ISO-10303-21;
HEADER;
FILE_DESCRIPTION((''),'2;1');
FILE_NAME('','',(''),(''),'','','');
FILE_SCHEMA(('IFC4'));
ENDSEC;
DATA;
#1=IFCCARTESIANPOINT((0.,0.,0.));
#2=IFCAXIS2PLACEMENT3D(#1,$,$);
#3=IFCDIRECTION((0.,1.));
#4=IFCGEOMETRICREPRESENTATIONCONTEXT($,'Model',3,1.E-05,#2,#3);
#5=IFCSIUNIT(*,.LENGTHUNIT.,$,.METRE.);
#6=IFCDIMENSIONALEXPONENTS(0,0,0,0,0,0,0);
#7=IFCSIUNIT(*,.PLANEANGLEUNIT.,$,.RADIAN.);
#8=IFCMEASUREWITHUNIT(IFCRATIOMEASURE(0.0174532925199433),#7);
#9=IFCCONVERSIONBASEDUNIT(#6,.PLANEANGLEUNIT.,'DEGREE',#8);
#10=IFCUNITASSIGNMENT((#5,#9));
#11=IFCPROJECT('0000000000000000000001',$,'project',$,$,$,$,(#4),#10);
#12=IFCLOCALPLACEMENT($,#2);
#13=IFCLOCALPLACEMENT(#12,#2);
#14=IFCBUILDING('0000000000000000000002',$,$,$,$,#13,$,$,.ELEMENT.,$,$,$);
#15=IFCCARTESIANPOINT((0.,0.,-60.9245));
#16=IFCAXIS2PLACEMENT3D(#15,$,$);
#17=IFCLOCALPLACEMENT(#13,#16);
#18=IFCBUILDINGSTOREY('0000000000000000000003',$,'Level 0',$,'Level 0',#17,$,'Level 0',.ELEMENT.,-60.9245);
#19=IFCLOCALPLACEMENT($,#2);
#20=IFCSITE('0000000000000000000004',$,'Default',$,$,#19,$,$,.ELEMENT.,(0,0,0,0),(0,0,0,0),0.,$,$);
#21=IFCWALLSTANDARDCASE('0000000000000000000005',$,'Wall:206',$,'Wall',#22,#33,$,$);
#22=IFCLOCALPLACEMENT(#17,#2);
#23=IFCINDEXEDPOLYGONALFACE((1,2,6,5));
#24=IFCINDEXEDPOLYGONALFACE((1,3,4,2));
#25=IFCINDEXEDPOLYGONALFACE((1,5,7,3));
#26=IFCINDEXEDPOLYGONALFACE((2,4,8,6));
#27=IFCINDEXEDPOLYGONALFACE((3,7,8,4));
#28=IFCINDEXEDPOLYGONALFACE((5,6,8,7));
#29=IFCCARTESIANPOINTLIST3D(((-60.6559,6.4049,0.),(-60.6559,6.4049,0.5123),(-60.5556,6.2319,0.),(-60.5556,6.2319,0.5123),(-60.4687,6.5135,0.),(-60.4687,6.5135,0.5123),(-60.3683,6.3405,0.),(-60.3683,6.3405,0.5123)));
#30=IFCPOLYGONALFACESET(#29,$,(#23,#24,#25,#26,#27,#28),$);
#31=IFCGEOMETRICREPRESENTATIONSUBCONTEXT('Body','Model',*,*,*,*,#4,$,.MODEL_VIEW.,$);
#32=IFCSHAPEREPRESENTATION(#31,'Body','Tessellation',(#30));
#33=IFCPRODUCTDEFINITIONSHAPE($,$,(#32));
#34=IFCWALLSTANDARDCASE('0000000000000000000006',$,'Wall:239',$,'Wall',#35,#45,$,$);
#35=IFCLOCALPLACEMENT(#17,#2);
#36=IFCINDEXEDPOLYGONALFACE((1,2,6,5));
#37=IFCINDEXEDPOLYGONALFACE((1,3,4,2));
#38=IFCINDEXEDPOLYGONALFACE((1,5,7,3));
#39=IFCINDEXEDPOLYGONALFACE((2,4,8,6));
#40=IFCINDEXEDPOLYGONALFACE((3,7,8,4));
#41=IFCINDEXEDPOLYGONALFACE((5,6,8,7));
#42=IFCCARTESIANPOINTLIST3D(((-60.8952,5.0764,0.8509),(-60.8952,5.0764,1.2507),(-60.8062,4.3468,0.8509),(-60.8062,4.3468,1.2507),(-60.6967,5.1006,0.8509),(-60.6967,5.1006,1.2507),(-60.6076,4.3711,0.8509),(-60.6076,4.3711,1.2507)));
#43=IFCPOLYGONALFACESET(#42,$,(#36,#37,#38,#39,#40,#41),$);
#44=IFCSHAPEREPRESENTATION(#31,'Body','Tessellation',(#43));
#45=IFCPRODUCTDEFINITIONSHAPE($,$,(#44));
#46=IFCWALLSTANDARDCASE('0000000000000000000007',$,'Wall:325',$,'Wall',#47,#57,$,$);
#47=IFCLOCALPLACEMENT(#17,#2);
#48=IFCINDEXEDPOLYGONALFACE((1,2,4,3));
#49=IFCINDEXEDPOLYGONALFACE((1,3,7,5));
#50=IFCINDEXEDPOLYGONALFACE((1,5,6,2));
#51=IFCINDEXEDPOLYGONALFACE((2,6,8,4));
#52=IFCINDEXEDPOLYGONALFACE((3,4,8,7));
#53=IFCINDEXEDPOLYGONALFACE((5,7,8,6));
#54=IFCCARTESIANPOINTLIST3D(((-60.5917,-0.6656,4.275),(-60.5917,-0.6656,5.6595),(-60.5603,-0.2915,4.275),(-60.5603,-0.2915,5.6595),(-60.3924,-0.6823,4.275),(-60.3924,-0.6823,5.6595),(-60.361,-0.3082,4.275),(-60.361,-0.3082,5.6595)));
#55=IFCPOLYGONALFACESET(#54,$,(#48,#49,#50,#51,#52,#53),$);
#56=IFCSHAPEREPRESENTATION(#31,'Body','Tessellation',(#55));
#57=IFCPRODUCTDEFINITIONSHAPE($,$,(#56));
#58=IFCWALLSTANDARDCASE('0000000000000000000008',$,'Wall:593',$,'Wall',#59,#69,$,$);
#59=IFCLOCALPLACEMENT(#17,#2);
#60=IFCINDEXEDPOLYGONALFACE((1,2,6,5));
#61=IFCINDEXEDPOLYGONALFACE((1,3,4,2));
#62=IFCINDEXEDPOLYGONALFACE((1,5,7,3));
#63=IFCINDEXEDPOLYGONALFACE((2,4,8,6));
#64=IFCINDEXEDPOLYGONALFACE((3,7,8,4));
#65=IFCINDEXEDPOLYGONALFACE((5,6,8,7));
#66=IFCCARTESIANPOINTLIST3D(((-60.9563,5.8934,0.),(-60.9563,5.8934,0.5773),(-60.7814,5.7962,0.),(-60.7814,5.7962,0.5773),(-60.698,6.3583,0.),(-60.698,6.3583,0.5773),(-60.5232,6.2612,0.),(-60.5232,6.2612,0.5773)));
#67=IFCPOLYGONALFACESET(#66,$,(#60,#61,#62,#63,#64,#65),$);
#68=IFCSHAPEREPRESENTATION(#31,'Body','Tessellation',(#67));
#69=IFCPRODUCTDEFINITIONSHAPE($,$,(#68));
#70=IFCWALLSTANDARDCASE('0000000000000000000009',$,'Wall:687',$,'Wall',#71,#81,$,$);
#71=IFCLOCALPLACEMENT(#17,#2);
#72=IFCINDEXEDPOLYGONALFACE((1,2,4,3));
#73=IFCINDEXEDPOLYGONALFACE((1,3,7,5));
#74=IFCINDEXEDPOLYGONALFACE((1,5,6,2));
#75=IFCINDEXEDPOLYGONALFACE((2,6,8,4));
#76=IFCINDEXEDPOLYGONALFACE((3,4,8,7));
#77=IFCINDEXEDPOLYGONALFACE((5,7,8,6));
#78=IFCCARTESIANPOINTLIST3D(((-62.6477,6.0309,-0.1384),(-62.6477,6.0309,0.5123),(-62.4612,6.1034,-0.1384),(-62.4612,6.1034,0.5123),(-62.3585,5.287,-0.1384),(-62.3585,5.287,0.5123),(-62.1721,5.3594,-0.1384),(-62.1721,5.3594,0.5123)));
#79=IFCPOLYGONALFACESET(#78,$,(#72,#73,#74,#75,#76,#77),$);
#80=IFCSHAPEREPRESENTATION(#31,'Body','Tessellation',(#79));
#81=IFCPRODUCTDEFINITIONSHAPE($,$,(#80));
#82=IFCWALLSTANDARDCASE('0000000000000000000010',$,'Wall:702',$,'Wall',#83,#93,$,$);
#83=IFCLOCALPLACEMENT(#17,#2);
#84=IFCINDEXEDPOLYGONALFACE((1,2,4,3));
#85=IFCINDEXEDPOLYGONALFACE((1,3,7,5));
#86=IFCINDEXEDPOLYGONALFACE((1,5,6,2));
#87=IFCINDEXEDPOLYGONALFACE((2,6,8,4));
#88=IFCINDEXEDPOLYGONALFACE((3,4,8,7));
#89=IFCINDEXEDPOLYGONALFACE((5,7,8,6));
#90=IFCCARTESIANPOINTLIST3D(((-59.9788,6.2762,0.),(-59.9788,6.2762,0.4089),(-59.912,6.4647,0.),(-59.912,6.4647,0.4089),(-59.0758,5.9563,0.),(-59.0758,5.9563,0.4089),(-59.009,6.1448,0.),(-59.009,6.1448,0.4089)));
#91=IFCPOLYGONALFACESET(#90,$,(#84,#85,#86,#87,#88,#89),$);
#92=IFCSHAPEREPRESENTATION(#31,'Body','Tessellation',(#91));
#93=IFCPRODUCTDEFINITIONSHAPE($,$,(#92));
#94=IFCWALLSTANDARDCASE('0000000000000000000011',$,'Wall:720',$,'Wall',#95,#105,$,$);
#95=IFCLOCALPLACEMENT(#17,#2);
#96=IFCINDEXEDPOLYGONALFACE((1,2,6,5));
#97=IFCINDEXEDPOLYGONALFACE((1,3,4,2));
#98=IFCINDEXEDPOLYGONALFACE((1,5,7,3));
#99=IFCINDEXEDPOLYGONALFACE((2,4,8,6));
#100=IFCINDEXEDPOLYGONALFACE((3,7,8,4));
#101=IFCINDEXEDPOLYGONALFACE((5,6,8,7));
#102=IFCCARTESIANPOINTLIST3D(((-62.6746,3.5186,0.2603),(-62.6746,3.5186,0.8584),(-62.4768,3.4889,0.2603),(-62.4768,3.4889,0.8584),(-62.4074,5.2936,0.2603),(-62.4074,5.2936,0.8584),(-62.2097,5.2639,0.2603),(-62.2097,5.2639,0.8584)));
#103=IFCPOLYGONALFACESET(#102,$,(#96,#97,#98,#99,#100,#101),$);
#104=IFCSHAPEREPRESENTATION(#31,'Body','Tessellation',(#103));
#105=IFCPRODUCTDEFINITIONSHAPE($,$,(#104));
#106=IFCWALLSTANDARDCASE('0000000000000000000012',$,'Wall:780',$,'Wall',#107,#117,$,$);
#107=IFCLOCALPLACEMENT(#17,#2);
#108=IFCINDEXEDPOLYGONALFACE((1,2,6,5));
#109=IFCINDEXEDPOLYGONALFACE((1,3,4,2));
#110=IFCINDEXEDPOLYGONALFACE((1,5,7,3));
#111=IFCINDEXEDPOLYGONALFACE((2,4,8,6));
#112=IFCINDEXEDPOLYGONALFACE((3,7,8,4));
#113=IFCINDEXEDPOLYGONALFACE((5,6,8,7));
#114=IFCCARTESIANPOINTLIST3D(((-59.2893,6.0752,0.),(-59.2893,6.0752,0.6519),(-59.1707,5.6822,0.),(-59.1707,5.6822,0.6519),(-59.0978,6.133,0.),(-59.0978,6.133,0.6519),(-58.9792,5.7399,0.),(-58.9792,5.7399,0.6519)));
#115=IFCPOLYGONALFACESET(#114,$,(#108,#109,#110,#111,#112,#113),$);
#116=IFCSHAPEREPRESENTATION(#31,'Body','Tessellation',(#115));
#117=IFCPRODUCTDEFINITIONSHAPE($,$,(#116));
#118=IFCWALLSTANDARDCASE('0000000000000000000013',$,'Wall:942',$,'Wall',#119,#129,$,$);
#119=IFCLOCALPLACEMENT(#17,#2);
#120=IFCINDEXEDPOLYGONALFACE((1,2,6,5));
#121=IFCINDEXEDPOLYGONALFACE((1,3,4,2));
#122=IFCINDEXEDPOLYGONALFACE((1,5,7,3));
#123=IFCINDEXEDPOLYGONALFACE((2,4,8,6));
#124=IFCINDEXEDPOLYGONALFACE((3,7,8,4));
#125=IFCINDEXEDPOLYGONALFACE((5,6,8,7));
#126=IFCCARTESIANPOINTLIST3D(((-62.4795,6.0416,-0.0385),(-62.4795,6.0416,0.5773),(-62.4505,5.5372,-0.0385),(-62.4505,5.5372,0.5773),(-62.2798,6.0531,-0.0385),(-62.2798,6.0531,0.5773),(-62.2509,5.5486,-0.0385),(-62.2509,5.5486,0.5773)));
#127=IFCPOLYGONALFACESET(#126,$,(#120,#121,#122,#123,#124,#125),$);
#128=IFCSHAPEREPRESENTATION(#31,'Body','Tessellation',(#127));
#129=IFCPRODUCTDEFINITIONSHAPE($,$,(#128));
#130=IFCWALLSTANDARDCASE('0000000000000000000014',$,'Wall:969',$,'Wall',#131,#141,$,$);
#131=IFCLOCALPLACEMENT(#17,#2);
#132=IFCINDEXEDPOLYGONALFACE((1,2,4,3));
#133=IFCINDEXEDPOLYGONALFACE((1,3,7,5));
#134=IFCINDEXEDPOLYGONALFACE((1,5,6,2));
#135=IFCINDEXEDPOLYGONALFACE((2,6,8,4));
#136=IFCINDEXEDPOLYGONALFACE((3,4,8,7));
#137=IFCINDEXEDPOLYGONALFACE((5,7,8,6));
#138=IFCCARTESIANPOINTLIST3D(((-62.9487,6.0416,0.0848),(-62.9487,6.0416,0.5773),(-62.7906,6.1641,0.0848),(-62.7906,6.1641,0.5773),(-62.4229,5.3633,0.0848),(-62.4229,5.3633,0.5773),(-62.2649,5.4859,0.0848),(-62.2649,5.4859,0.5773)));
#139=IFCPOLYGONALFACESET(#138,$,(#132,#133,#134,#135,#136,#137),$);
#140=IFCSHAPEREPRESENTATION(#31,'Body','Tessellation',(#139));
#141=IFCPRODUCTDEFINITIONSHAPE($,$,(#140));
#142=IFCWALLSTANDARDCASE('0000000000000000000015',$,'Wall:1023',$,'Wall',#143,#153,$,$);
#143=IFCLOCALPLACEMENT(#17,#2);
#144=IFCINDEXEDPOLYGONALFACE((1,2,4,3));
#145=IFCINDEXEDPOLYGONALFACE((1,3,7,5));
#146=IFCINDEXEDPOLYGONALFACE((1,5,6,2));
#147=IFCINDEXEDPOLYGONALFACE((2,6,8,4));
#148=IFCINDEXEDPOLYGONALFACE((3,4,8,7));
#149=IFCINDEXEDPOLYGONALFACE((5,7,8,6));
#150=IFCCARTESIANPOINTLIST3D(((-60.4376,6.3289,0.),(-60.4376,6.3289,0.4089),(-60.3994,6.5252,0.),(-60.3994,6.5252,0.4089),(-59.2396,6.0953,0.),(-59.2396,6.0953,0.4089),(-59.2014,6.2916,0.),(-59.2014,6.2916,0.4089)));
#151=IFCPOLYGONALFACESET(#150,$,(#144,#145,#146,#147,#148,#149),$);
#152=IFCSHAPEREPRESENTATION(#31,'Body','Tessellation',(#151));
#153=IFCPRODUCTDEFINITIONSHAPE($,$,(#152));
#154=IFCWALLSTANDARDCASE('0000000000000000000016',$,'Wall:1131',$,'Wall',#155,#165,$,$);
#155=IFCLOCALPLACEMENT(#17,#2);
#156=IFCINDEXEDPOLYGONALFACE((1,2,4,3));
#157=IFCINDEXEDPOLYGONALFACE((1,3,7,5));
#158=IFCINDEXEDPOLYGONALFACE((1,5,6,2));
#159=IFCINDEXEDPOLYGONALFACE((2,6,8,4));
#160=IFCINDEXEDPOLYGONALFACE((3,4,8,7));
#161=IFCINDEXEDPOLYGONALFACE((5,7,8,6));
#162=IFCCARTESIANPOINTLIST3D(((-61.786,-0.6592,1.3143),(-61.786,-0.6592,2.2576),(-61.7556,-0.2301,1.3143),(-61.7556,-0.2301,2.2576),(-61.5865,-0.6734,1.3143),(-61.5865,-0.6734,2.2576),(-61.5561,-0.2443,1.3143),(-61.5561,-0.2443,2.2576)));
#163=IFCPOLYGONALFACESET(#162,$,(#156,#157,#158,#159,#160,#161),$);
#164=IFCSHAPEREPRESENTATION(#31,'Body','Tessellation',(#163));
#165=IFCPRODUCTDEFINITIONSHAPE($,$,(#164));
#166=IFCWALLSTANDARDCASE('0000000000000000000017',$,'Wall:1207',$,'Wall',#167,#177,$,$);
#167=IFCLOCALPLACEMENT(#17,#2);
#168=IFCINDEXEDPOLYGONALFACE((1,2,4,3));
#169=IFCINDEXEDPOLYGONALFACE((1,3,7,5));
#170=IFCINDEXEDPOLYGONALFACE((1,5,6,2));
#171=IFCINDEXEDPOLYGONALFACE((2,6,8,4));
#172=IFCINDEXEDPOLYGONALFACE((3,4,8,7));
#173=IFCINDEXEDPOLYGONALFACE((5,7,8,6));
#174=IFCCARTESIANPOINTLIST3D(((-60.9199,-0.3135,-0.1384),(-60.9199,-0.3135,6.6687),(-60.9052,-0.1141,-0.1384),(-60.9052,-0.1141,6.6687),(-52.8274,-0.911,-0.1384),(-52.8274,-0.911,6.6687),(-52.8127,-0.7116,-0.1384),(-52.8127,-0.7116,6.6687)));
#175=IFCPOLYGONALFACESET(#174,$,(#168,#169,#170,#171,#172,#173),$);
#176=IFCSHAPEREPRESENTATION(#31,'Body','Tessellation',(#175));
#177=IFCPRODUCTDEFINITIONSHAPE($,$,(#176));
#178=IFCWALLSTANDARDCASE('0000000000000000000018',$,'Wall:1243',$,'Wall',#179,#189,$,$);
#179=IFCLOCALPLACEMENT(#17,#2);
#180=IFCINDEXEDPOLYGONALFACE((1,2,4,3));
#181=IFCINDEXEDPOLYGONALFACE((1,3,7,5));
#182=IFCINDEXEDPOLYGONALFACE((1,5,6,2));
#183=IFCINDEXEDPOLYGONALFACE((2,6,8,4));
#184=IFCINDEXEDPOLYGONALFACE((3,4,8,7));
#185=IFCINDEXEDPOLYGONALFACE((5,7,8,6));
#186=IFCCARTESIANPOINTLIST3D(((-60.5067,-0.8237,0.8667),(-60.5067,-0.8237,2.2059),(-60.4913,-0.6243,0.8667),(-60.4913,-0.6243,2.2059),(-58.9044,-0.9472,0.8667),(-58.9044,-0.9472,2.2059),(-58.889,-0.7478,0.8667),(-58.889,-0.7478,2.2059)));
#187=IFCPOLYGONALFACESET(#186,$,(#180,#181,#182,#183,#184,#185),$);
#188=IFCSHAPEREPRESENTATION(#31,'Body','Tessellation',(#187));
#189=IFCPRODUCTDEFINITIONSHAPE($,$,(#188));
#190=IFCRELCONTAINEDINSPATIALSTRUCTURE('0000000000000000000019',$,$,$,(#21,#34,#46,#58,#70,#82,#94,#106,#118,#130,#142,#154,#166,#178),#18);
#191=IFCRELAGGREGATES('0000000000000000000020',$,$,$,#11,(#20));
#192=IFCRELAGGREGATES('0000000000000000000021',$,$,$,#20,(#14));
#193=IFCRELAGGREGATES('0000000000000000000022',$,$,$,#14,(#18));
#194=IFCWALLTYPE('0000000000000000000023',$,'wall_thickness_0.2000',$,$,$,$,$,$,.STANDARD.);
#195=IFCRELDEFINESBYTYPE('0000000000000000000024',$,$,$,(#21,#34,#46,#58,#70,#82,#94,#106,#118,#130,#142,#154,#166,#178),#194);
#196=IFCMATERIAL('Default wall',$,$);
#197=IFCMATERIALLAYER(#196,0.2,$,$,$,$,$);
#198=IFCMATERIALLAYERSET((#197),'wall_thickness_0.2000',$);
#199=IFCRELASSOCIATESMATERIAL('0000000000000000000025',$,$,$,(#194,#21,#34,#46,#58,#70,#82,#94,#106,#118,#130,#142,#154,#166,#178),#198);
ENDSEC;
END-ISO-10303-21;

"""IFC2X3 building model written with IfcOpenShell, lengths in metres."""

from ifc_helpers import new_model, entity, si_unit, converted_unit, direction, frame, origin, place, context, subcontext, project, spatial, polyline, outline, extrude, material, layer, layer_set, layer_usage, type_object, element, save


model = new_model("IFC2X3")

# Units and contexts
model_context = context("Model", 3, precision=1e-05, world=origin(), true_north=direction((0.0, 1.0)))
body_context = subcontext(model_context, "Body", "Model", "MODEL_VIEW")
ifc_project = project(units=[si_unit("LENGTHUNIT", "METRE"), converted_unit("PLANEANGLEUNIT", "DEGREE", entity("IfcRatioMeasure", 0.0174532925199433), si_unit("PLANEANGLEUNIT", "RADIAN"), dimensions=[0, 0, 0, 0, 0, 0, 0])], contexts=[model_context])

# Site, building, storey
site_placement = place(None, origin())
site = spatial("IfcSite", under=ifc_project, at=site_placement, Name="Default", CompositionType="ELEMENT", RefLatitude=(0, 0, 0, 0), RefLongitude=(0, 0, 0, 0), RefElevation=0.0)
placement_1 = place(None, origin())
building_placement = place(placement_1, origin())
building = spatial("IfcBuilding", under=site, at=building_placement, CompositionType="ELEMENT")
storey_placement = place(building_placement, frame((0.0, 0.0, -60.9245)))
storey = spatial("IfcBuildingStorey", under=building, at=storey_placement, Name="Level 0", ObjectType="Level 0", LongName="Level 0", CompositionType="ELEMENT", Elevation=-60.9245)

# Walls
ifc_material = material(Name="Default wall")
ifc_layer = layer(ifc_material, 0.2)
ifc_layer_set = layer_set([ifc_layer], Name="wall_thickness_0.2000")
ifc_layer_usage = layer_usage(ifc_layer_set, "AXIS2", "POSITIVE", -0.1)
wall_type = type_object("IfcWallType", Name="wall_thickness_0.2000", PredefinedType="STANDARD", material=ifc_layer_set)
wall_1_placement = place(storey_placement, frame((-60.6058, 6.3184, 0.0), z_axis=(0.0, 0.0, 1.0), x_axis=(0.864993, 0.501783, 0.0)))
element("IfcWallStandardCase", 1, at=wall_1_placement, inside=storey, type_object=wall_type, material=ifc_layer_usage, Name="Wall:206", ObjectType="Wall", context=body_context, shape_type="SweptSolid", body=[
    extrude(outline(polyline([(0.2165, -0.1), (0.2165, 0.1), (0.0, 0.1), (0.0, -0.1), (0.2165, -0.1)])), origin(), (0.0, 0.0, 1.0), 0.5123),
])
placement_2 = place(building_placement, frame((0.0, 0.0, -60.0736)))
wall_2_placement = place(placement_2, frame((-60.796, 5.0885, 0.0), z_axis=(0.0, 0.0, 1.0), x_axis=(0.121209, -0.992627, 0.0)))
element("IfcWallStandardCase", 2, at=wall_2_placement, inside=storey, type_object=wall_type, material=ifc_layer_usage, Name="Wall:239", ObjectType="Wall", context=body_context, shape_type="SweptSolid", body=[
    extrude(outline(polyline([(0.735, -0.1), (0.735, 0.1), (0.0, 0.1), (0.0, -0.1), (0.735, -0.1)])), origin(), (0.0, 0.0, 1.0), 0.3998),
])
placement_3 = place(building_placement, frame((0.0, 0.0, -56.6495)))
wall_3_placement = place(placement_3, frame((-60.492, -0.6739, 0.0), z_axis=(0.0, 0.0, 1.0), x_axis=(0.08355, 0.996504, 0.0)))
element("IfcWallStandardCase", 3, at=wall_3_placement, inside=storey, type_object=wall_type, material=ifc_layer_usage, Name="Wall:325", ObjectType="Wall", context=body_context, shape_type="SweptSolid", body=[
    extrude(outline(polyline([(0.3754, -0.1), (0.3754, 0.1), (0.0, 0.1), (0.0, -0.1), (0.3754, -0.1)])), origin(), (0.0, 0.0, 1.0), 1.3845),
])
wall_4_placement = place(storey_placement, frame((-60.8689, 5.8448, 0.0), z_axis=(0.0, 0.0, 1.0), x_axis=(0.485631, 0.874164, 0.0)))
element("IfcWallStandardCase", 4, at=wall_4_placement, inside=storey, type_object=wall_type, material=ifc_layer_usage, Name="Wall:593", ObjectType="Wall", context=body_context, shape_type="SweptSolid", body=[
    extrude(outline(polyline([(0.5319, -0.1), (0.5319, 0.1), (0.0, 0.1), (0.0, -0.1), (0.5319, -0.1)])), origin(), (0.0, 0.0, 1.0), 0.5773),
])
placement_4 = place(building_placement, frame((0.0, 0.0, -61.0629)))
wall_5_placement = place(placement_4, frame((-62.2653, 5.3232, 0.0), z_axis=(0.0, 0.0, 1.0), x_axis=(-0.362264, 0.932076, 0.0)))
element("IfcWallStandardCase", 5, at=wall_5_placement, inside=storey, type_object=wall_type, material=ifc_layer_usage, Name="Wall:687", ObjectType="Wall", context=body_context, shape_type="SweptSolid", body=[
    extrude(outline(polyline([(0.7982, -0.1), (0.7982, 0.1), (0.0, 0.1), (0.0, -0.1), (0.7982, -0.1)])), origin(), (0.0, 0.0, 1.0), 0.6506),
])
wall_6_placement = place(storey_placement, frame((-59.0424, 6.0506, 0.0), z_axis=(0.0, 0.0, 1.0), x_axis=(-0.942624, 0.333856, 0.0)))
element("IfcWallStandardCase", 6, at=wall_6_placement, inside=storey, type_object=wall_type, material=ifc_layer_usage, Name="Wall:702", ObjectType="Wall", context=body_context, shape_type="SweptSolid", body=[
    extrude(outline(polyline([(0.958, -0.1), (0.958, 0.1), (0.0, 0.1), (0.0, -0.1), (0.958, -0.1)])), origin(), (0.0, 0.0, 1.0), 0.4089),
])
placement_5 = place(building_placement, frame((0.0, 0.0, -60.6642)))
wall_7_placement = place(placement_5, frame((-62.5757, 3.5038, 0.0), z_axis=(0.0, 0.0, 1.0), x_axis=(0.148826, 0.988863, 0.0)))
element("IfcWallStandardCase", 7, at=wall_7_placement, inside=storey, type_object=wall_type, material=ifc_layer_usage, Name="Wall:720", ObjectType="Wall", context=body_context, shape_type="SweptSolid", body=[
    extrude(outline(polyline([(1.795, -0.1), (1.795, 0.1), (0.0, 0.1), (0.0, -0.1), (1.795, -0.1)])), origin(), (0.0, 0.0, 1.0), 0.5981),
])
wall_8_placement = place(storey_placement, frame((-59.075, 5.7111, 0.0), z_axis=(0.0, 0.0, 1.0), x_axis=(-0.288823, 0.957383, 0.0)))
element("IfcWallStandardCase", 8, at=wall_8_placement, inside=storey, type_object=wall_type, material=ifc_layer_usage, Name="Wall:780", ObjectType="Wall", context=body_context, shape_type="SweptSolid", body=[
    extrude(outline(polyline([(0.4105, -0.1), (0.4105, 0.1), (0.0, 0.1), (0.0, -0.1), (0.4105, -0.1)])), origin(), (0.0, 0.0, 1.0), 0.6519),
])
placement_6 = place(building_placement, frame((0.0, 0.0, -60.963)))
wall_9_placement = place(placement_6, frame((-62.3507, 5.5429, 0.0), z_axis=(0.0, 0.0, 1.0), x_axis=(-0.057312, 0.998356, 0.0)))
element("IfcWallStandardCase", 9, at=wall_9_placement, inside=storey, type_object=wall_type, material=ifc_layer_usage, Name="Wall:942", ObjectType="Wall", context=body_context, shape_type="SweptSolid", body=[
    extrude(outline(polyline([(0.5053, -0.1), (0.5053, 0.1), (0.0, 0.1), (0.0, -0.1), (0.5053, -0.1)])), origin(), (0.0, 0.0, 1.0), 0.6158),
])
placement_7 = place(building_placement, frame((0.0, 0.0, -60.8397)))
wall_10_placement = place(placement_7, frame((-62.8696, 6.1029, 0.0), z_axis=(0.0, 0.0, 1.0), x_axis=(0.612608, -0.790387, 0.0)))
element("IfcWallStandardCase", 10, at=wall_10_placement, inside=storey, type_object=wall_type, material=ifc_layer_usage, Name="Wall:969", ObjectType="Wall", context=body_context, shape_type="SweptSolid", body=[
    extrude(outline(polyline([(0.8582, -0.1), (0.8582, 0.1), (0.0, 0.1), (0.0, -0.1), (0.8582, -0.1)])), origin(), (0.0, 0.0, 1.0), 0.4925),
])
wall_11_placement = place(storey_placement, frame((-60.4185, 6.427, 0.0), z_axis=(0.0, 0.0, 1.0), x_axis=(0.981525, -0.191334, 0.0)))
element("IfcWallStandardCase", 11, at=wall_11_placement, inside=storey, type_object=wall_type, material=ifc_layer_usage, Name="Wall:1023", ObjectType="Wall", context=body_context, shape_type="SweptSolid", body=[
    extrude(outline(polyline([(1.2205, -0.1), (1.2205, 0.1), (0.0, 0.1), (0.0, -0.1), (1.2205, -0.1)])), origin(), (0.0, 0.0, 1.0), 0.4089),
])
placement_8 = place(building_placement, frame((0.0, 0.0, -59.6102)))
wall_12_placement = place(placement_8, frame((-61.6558, -0.2372, 0.0), z_axis=(0.0, 0.0, 1.0), x_axis=(-0.070702, -0.997498, 0.0)))
element("IfcWallStandardCase", 12, at=wall_12_placement, inside=storey, type_object=wall_type, material=ifc_layer_usage, Name="Wall:1131", ObjectType="Wall", context=body_context, shape_type="SweptSolid", body=[
    extrude(outline(polyline([(0.4302, -0.1), (0.4302, 0.1), (0.0, 0.1), (0.0, -0.1), (0.4302, -0.1)])), origin(), (0.0, 0.0, 1.0), 0.9433),
])
placement_9 = place(building_placement, frame((0.0, 0.0, -61.0629)))
wall_13_placement = place(placement_9, frame((-60.9126, -0.2138, 0.0), z_axis=(0.0, 0.0, 1.0), x_axis=(0.997286, -0.073629, 0.0)))
element("IfcWallStandardCase", 13, at=wall_13_placement, inside=storey, type_object=wall_type, material=ifc_layer_usage, Name="Wall:1207", ObjectType="Wall", context=body_context, shape_type="SweptSolid", body=[
    extrude(outline(polyline([(8.1145, -0.1), (8.1145, 0.1), (0.0, 0.1), (0.0, -0.1), (8.1145, -0.1)])), origin(), (0.0, 0.0, 1.0), 6.807),
])
placement_10 = place(building_placement, frame((0.0, 0.0, -60.0578)))
wall_14_placement = place(placement_10, frame((-60.499, -0.724, 0.0), z_axis=(0.0, 0.0, 1.0), x_axis=(0.997043, -0.076849, 0.0)))
element("IfcWallStandardCase", 14, at=wall_14_placement, inside=storey, type_object=wall_type, material=ifc_layer_usage, Name="Wall:1243", ObjectType="Wall", context=body_context, shape_type="SweptSolid", body=[
    extrude(outline(polyline([(1.6071, -0.1), (1.6071, 0.1), (0.0, 0.1), (0.0, -0.1), (1.6071, -0.1)])), origin(), (0.0, 0.0, 1.0), 1.3392),
])

save(model, "model.ifc")
